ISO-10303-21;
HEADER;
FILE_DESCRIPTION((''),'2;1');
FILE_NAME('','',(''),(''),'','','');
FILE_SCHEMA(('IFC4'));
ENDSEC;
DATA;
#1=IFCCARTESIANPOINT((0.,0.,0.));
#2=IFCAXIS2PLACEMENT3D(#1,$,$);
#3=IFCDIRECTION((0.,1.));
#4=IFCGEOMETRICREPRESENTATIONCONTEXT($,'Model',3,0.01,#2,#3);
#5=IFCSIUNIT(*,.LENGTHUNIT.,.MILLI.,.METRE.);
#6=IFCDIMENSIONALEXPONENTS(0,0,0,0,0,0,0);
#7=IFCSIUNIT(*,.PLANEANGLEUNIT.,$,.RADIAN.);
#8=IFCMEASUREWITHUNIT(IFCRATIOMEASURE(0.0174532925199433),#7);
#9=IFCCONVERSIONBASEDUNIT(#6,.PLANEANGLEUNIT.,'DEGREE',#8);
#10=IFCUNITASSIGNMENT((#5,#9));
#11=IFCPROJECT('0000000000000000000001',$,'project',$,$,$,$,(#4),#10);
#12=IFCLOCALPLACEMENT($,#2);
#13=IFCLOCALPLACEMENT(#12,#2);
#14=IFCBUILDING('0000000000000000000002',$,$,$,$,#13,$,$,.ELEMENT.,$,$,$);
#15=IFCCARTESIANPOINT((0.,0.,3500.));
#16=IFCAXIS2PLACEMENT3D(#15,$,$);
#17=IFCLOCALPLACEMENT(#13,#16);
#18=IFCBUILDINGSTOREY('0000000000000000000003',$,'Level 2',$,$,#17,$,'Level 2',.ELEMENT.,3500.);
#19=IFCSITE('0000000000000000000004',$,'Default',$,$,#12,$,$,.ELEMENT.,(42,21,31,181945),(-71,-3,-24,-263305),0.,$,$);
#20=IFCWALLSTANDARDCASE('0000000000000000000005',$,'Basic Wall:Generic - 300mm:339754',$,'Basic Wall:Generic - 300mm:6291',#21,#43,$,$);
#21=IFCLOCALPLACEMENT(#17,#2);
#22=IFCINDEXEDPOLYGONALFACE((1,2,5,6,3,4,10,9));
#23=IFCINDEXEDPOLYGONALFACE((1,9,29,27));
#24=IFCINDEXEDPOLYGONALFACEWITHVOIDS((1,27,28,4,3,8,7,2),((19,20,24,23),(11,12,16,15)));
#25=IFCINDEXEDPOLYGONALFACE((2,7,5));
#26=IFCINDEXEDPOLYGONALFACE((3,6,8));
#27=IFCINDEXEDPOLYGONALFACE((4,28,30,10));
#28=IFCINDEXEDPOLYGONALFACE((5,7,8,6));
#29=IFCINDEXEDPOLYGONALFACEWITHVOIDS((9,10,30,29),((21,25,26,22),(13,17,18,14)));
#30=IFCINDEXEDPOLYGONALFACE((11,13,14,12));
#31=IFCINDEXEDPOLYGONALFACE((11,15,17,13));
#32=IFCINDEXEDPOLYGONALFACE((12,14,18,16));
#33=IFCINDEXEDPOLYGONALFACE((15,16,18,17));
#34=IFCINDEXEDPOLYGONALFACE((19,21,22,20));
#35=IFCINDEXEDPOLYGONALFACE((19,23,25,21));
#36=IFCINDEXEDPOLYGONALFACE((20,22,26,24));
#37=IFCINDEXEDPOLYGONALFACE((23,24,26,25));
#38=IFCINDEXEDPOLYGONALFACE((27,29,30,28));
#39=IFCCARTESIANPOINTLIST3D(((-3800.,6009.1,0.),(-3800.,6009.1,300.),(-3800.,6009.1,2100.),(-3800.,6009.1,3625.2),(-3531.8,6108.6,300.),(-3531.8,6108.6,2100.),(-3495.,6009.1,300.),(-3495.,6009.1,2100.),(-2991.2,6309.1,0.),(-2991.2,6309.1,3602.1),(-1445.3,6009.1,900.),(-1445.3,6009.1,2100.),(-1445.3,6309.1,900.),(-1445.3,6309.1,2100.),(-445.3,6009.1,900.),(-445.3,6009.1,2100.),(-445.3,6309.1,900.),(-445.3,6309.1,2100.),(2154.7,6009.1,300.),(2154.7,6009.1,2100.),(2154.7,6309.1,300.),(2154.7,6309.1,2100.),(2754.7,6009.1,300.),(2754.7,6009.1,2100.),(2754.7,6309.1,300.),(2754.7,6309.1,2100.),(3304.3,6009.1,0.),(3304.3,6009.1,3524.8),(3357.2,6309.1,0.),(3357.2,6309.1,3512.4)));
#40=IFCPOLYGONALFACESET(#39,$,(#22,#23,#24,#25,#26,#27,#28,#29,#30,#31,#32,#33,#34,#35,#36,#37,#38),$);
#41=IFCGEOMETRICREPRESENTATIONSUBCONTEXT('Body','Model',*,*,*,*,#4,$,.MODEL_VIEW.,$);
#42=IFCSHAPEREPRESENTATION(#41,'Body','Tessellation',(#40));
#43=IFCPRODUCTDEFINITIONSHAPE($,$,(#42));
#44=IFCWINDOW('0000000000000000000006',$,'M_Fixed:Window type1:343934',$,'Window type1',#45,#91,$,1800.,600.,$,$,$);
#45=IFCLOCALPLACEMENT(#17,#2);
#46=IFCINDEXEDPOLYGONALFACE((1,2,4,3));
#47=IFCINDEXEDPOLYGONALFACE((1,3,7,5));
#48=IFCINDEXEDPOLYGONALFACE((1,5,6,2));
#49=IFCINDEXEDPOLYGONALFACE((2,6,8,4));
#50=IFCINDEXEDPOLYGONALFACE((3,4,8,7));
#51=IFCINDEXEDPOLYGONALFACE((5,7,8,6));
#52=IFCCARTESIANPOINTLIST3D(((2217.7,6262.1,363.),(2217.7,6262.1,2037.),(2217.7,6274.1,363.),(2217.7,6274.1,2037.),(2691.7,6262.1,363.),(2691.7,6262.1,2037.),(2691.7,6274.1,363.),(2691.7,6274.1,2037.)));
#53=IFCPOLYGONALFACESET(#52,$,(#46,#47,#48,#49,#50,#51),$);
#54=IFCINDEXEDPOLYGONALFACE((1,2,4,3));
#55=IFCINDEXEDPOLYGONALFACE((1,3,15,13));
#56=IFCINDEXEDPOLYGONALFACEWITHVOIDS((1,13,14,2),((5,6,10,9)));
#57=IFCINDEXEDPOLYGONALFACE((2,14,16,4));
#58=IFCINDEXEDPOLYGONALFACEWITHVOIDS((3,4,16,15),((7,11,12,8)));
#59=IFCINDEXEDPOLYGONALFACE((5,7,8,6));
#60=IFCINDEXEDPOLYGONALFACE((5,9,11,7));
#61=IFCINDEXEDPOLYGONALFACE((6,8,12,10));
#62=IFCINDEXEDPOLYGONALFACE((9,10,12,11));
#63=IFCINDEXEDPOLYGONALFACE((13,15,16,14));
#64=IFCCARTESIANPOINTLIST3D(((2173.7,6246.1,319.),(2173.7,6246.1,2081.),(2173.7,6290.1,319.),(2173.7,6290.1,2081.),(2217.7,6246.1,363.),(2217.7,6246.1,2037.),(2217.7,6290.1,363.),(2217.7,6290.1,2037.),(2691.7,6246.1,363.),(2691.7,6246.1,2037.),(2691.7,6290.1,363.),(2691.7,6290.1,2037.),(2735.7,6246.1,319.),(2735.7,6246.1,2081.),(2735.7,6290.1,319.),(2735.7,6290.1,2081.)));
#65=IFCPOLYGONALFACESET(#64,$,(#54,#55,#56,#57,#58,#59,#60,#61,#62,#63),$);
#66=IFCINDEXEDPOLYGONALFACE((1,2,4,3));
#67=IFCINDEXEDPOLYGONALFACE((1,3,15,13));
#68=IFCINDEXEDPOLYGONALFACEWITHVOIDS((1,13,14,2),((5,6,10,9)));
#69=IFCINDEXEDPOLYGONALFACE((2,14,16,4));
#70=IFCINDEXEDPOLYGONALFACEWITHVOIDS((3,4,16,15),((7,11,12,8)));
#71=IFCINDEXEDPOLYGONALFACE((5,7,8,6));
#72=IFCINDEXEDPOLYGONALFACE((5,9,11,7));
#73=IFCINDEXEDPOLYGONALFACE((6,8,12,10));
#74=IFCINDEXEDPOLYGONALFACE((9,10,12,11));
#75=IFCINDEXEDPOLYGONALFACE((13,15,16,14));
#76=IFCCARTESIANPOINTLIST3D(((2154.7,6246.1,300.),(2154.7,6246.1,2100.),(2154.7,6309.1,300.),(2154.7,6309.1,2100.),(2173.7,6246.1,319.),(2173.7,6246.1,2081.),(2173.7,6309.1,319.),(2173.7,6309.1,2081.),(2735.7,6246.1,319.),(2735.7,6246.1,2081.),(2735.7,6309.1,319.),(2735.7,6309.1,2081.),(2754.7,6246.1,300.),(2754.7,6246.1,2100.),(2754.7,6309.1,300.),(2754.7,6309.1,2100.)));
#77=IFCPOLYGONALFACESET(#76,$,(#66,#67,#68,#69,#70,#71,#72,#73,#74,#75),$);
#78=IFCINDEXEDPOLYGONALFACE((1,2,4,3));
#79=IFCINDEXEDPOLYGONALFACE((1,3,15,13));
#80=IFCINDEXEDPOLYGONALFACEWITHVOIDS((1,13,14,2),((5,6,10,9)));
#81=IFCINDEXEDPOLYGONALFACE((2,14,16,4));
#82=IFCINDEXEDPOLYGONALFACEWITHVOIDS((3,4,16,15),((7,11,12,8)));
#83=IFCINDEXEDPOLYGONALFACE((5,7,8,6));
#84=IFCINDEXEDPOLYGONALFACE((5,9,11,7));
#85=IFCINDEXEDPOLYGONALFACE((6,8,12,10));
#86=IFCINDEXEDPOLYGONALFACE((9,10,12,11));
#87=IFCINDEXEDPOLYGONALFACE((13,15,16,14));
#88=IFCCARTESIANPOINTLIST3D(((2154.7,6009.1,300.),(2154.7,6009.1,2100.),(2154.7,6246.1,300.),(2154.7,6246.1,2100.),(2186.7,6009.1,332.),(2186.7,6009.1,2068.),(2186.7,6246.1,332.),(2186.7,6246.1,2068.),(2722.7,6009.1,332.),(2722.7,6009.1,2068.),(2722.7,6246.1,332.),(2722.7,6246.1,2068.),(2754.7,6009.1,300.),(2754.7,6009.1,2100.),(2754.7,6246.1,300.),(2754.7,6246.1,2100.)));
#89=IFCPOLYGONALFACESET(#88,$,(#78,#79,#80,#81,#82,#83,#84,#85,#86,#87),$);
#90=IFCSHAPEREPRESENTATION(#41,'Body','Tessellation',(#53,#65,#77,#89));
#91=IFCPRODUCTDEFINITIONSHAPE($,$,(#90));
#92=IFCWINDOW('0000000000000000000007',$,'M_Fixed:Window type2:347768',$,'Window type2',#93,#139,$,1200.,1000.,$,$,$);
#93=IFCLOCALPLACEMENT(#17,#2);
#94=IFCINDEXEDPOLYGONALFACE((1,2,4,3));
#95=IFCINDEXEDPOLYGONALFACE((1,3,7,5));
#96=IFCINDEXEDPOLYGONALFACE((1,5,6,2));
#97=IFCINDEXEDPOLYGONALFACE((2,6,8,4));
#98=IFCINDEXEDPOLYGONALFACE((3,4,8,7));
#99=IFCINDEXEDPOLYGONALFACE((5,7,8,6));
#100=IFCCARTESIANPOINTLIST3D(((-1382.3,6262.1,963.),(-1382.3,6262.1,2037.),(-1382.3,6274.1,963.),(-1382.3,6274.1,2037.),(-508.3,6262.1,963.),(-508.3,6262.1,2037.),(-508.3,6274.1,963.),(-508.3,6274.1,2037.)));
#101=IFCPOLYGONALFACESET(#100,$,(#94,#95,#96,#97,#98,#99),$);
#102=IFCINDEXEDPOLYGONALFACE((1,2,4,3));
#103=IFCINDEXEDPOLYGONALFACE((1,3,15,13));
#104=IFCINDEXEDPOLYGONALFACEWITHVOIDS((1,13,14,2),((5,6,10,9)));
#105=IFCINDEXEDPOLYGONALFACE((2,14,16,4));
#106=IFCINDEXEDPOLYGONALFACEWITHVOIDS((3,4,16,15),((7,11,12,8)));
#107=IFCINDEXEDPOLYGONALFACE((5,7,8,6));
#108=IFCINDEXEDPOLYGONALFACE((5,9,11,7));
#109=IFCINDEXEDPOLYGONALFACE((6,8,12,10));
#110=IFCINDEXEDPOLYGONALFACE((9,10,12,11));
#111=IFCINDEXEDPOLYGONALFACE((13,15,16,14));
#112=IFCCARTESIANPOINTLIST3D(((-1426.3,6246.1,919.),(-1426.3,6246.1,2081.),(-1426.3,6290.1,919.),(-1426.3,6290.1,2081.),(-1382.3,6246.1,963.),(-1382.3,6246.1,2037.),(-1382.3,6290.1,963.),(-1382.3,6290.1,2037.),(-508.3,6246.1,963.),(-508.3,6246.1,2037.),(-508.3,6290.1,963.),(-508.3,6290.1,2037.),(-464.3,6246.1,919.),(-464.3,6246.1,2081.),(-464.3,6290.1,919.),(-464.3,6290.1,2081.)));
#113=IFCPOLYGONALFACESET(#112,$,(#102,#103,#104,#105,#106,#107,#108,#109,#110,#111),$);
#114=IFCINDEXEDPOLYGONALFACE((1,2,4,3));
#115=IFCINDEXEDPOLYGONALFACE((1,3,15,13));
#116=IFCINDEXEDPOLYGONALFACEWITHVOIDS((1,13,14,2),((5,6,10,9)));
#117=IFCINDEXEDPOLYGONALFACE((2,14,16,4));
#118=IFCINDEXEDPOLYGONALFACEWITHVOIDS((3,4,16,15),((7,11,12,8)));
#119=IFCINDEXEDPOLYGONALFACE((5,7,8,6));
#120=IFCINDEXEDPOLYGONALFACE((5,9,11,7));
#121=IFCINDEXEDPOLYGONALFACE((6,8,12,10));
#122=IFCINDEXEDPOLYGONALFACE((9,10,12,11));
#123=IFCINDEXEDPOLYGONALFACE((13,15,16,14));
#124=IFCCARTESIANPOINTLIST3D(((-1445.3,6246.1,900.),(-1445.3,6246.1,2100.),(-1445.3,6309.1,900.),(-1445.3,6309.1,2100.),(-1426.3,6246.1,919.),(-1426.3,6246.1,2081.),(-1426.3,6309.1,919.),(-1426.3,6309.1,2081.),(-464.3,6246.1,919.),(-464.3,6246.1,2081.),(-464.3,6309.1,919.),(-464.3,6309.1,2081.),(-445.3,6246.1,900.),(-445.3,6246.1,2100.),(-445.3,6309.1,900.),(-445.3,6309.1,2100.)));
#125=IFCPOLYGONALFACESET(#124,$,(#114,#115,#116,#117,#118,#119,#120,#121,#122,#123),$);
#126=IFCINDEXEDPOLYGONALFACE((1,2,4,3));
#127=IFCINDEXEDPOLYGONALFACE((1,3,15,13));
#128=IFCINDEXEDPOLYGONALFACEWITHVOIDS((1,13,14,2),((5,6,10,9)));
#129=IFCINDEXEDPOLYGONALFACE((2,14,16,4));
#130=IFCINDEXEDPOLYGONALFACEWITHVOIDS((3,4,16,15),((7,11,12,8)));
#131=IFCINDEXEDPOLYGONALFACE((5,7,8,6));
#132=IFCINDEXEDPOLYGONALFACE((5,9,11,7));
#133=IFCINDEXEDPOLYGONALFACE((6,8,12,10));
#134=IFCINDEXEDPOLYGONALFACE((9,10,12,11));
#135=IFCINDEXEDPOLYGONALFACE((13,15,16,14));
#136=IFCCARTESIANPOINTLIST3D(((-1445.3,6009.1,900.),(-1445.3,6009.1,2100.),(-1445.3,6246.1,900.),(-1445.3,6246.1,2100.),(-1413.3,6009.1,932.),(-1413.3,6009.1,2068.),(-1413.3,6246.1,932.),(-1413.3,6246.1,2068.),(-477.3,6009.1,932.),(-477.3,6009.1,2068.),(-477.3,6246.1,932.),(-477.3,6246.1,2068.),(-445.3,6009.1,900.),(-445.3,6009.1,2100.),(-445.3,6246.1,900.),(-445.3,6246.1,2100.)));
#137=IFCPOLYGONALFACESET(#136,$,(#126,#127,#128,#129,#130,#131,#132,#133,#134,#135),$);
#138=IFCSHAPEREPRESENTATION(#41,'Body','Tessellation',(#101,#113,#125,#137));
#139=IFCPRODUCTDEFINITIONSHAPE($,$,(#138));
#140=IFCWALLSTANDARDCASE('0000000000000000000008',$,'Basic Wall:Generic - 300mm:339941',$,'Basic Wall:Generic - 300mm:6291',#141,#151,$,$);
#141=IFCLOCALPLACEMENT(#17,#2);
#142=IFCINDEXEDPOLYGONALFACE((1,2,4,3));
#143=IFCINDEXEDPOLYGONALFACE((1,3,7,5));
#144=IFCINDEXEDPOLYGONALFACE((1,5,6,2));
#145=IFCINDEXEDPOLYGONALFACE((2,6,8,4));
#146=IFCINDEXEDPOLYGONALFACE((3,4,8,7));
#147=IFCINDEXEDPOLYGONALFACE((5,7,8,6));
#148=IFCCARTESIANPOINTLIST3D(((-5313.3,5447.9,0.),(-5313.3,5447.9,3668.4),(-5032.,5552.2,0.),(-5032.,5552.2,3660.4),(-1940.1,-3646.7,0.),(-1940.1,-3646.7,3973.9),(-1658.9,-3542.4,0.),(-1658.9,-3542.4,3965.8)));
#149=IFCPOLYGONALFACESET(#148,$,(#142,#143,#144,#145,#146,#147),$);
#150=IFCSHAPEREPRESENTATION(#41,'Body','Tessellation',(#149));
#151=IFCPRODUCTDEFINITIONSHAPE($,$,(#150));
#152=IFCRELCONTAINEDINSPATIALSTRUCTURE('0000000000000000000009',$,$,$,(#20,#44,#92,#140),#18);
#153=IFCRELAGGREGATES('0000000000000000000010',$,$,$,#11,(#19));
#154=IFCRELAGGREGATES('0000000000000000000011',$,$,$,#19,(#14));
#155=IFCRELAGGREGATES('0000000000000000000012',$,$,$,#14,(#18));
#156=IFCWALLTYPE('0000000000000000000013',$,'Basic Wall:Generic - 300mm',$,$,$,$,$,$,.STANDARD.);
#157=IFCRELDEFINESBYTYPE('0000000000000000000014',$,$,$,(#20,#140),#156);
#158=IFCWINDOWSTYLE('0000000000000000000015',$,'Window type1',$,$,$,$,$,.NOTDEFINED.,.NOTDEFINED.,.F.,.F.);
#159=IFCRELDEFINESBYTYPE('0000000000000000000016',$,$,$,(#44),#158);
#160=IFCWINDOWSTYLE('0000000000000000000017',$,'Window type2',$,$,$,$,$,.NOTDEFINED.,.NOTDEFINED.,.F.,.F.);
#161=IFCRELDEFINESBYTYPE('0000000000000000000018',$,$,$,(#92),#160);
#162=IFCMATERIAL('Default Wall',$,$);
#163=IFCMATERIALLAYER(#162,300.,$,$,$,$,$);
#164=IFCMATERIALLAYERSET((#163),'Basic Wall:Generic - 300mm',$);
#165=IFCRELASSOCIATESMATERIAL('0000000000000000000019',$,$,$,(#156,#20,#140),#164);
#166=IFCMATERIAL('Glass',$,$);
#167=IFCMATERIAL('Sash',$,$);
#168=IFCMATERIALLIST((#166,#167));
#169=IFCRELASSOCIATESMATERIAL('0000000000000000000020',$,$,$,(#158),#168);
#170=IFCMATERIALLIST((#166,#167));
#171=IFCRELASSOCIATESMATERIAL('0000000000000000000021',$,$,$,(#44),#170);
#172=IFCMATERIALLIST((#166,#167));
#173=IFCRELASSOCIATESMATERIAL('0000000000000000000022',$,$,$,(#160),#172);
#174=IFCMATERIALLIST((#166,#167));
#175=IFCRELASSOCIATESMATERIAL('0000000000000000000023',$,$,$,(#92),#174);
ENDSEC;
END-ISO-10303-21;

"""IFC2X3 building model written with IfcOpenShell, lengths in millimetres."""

from ifc_helpers import new_model, entity, si_unit, converted_unit, direction, frame, frame_2d, origin, place, context, subcontext, project, spatial, polyline, rectangle, outline, extrude, clip, bounded_halfspace, source, transform, mapped, material, material_list, layer, layer_set, layer_usage, type_object, type_shapes, element, fill, save


model = new_model("IFC2X3")

# Units and contexts
model_context = context("Model", 3, precision=0.01, world=origin(), true_north=direction((0.0, 1.0)))
body_context = subcontext(model_context, "Body", "Model", "MODEL_VIEW")
ifc_project = project(units=[si_unit("LENGTHUNIT", "METRE", prefix="MILLI"), converted_unit("PLANEANGLEUNIT", "DEGREE", entity("IfcRatioMeasure", 0.0174532925199433), si_unit("PLANEANGLEUNIT", "RADIAN"), dimensions=[0, 0, 0, 0, 0, 0, 0])], contexts=[model_context])

# Site, building, storey
site_placement = place(None, origin())
site = spatial("IfcSite", under=ifc_project, at=site_placement, Name="Default", CompositionType="ELEMENT", RefLatitude=(42, 21, 31, 181945), RefLongitude=(-71, -3, -24, -263305), RefElevation=0.0)
building_placement = place(site_placement, origin())
building = spatial("IfcBuilding", under=site, at=building_placement, CompositionType="ELEMENT")
storey_placement = place(building_placement, frame((0.0, 0.0, 3500.0)))
storey = spatial("IfcBuildingStorey", under=building, at=storey_placement, Name="Level 2", LongName="Level 2", CompositionType="ELEMENT", Elevation=3500.0)

# Wall, openings, windows
ifc_material_1 = material(Name="Default Wall")
ifc_layer_1 = layer(ifc_material_1, 300.0)
ifc_layer_set_1 = layer_set([ifc_layer_1], Name="Basic Wall:Generic - 300mm")
ifc_layer_usage_1 = layer_usage(ifc_layer_set_1, "AXIS2", "NEGATIVE", 150.0)
wall_type = type_object("IfcWallType", Name="Basic Wall:Generic - 300mm", PredefinedType="STANDARD", material=ifc_layer_set_1)
wall_1_placement = place(storey_placement, frame((-3800.0, 6159.1, 0.0)))
wall_1 = element("IfcWallStandardCase", 1, at=wall_1_placement, inside=storey, type_object=wall_type, material=ifc_layer_usage_1, Name="Basic Wall:Generic - 300mm:339754", ObjectType="Basic Wall:Generic - 300mm:6291", context=body_context, shape_type="Clipping", body=[
    clip(extrude(outline(polyline([(7104.3, -150.0), (7157.2, 150.0), (808.9, 150.0), (0.0, -150.0), (862.7, -150.0), (7104.3, -150.0)])), origin(), (0.0, 0.0, 1.0), 3625.2), bounded_halfspace(frame((0.0, -150.0, 3625.2), z_axis=(0.014121, 0.038797, 0.999147), x_axis=(-0.939693, 0.34202, 0.0)), False, frame((0.0, -150.0, 3625.2)), polyline([(0.0, 0.0), (862.7, 0.0), (7104.3, 0.0), (7157.2, 300.0), (808.9, 300.0), (0.0, 0.0)]))),
])
opening_1_placement = place(wall_1_placement, origin())
element("IfcOpeningElement", 2, at=opening_1_placement, cuts=wall_1, ObjectType="Opening", context=body_context, shape_type="SweptSolid", body=[
    extrude(rectangle(XDim=1800.0, YDim=600.0, at=frame_2d((0.0, 0.0), x_axis=(0.0, 1.0))), frame((91.2, -436.1, 1200.0), z_axis=(-0.347744, 0.937589, 0.0), x_axis=(-0.937589, -0.347744, 0.0)), (0.0, 0.0, 1.0), 300.0),
])
opening_2_placement = place(wall_1_placement, frame((5954.7, -150.0, 300.0)))
opening_2 = element("IfcOpeningElement", 3, at=opening_2_placement, cuts=wall_1, ObjectType="Opening", context=body_context, shape_type="SweptSolid", body=[
    extrude(rectangle(XDim=1800.0, YDim=600.0, at=frame_2d((900.0, 300.0), x_axis=(1.0, 0.0))), frame((0.0, 0.0, 0.0), z_axis=(0.0, 1.0, 0.0), x_axis=(0.0, 0.0, 1.0)), (0.0, 0.0, 1.0), 300.0),
])
opening_3_placement = place(wall_1_placement, frame((2354.7, -150.0, 900.0)))
opening_3 = element("IfcOpeningElement", 4, at=opening_3_placement, cuts=wall_1, ObjectType="Opening", context=body_context, shape_type="SweptSolid", body=[
    extrude(rectangle(XDim=1200.0, YDim=1000.0, at=frame_2d((600.0, 500.0), x_axis=(1.0, 0.0))), frame((0.0, 0.0, 0.0), z_axis=(0.0, 1.0, 0.0), x_axis=(0.0, 0.0, 1.0)), (0.0, 0.0, 1.0), 300.0),
])
ifc_material_2 = material(Name="Glass")
ifc_material_3 = material(Name="Sash")
ifc_material_list_1 = material_list([ifc_material_2, ifc_material_3])
ifc_material_list_2 = material_list([ifc_material_2, ifc_material_3])
window_style_1 = type_object("IfcWindowStyle", Name="Window type1", ConstructionType="NOTDEFINED", OperationType="NOTDEFINED", ParameterTakesPrecedence=False, Sizeable=False, material=ifc_material_list_2)
shared_shape_1 = source(origin(), body_context, "Body", "SweptSolid", [
    extrude(rectangle(XDim=12.0, YDim=474.0, at=frame_2d((0.0, 0.0), x_axis=(1.0, 0.0))), frame((300.0, 259.0, 63.0), z_axis=(0.0, 0.0, 1.0), x_axis=(0.0, -1.0, 0.0)), (0.0, 0.0, 1.0), 1674.0),
    extrude(outline(polyline([(-281.0, -881.0), (281.0, -881.0), (281.0, 881.0), (-281.0, 881.0), (-281.0, -881.0)]), holes=[polyline([(-237.0, -837.0), (-237.0, 837.0), (237.0, 837.0), (237.0, -837.0), (-237.0, -837.0)])]), frame((300.0, 237.0, 900.0), z_axis=(0.0, 1.0, 0.0), x_axis=(1.0, 0.0, 0.0)), (0.0, 0.0, 1.0), 44.0),
    extrude(outline(polyline([(-300.0, -900.0), (300.0, -900.0), (300.0, 900.0), (-300.0, 900.0), (-300.0, -900.0)]), holes=[polyline([(-281.0, -881.0), (-281.0, 881.0), (281.0, 881.0), (281.0, -881.0), (-281.0, -881.0)])]), frame((300.0, 237.0, 900.0), z_axis=(0.0, 1.0, 0.0), x_axis=(1.0, 0.0, 0.0)), (0.0, 0.0, 1.0), 63.0),
    extrude(outline(polyline([(-300.0, -900.0), (300.0, -900.0), (300.0, 900.0), (-300.0, 900.0), (-300.0, -900.0)]), holes=[polyline([(-268.0, -868.0), (-268.0, 868.0), (268.0, 868.0), (268.0, -868.0), (-268.0, -868.0)])]), frame((300.0, 0.0, 900.0), z_axis=(0.0, 1.0, 0.0), x_axis=(1.0, 0.0, 0.0)), (0.0, 0.0, 1.0), 237.0),
])
type_shapes(window_style_1, [shared_shape_1])
window_1_placement = place(opening_2_placement, origin())
window_1 = element("IfcWindow", 5, at=window_1_placement, inside=storey, type_object=window_style_1, material=ifc_material_list_1, Name="M_Fixed:Window type1:343934", ObjectType="Window type1", OverallHeight=1800.0, OverallWidth=600.0, context=body_context, shape_type="MappedRepresentation", body=[
    mapped(shared_shape_1, transform((0.0, 0.0, 0.0), scale=1.0)),
])
fill(opening_2, window_1)
ifc_material_list_3 = material_list([ifc_material_2, ifc_material_3])
ifc_material_list_4 = material_list([ifc_material_2, ifc_material_3])
window_style_2 = type_object("IfcWindowStyle", Name="Window type2", ConstructionType="NOTDEFINED", OperationType="NOTDEFINED", ParameterTakesPrecedence=False, Sizeable=False, material=ifc_material_list_4)
shared_shape_2 = source(origin(), body_context, "Body", "SweptSolid", [
    extrude(rectangle(XDim=12.0, YDim=874.0, at=frame_2d((0.0, 0.0), x_axis=(1.0, 0.0))), frame((500.0, 259.0, 63.0), z_axis=(0.0, 0.0, 1.0), x_axis=(0.0, -1.0, 0.0)), (0.0, 0.0, 1.0), 1074.0),
    extrude(outline(polyline([(-481.0, -581.0), (481.0, -581.0), (481.0, 581.0), (-481.0, 581.0), (-481.0, -581.0)]), holes=[polyline([(-437.0, -537.0), (-437.0, 537.0), (437.0, 537.0), (437.0, -537.0), (-437.0, -537.0)])]), frame((500.0, 237.0, 600.0), z_axis=(0.0, 1.0, 0.0), x_axis=(1.0, 0.0, 0.0)), (0.0, 0.0, 1.0), 44.0),
    extrude(outline(polyline([(-500.0, -600.0), (500.0, -600.0), (500.0, 600.0), (-500.0, 600.0), (-500.0, -600.0)]), holes=[polyline([(-481.0, -581.0), (-481.0, 581.0), (481.0, 581.0), (481.0, -581.0), (-481.0, -581.0)])]), frame((500.0, 237.0, 600.0), z_axis=(0.0, 1.0, 0.0), x_axis=(1.0, 0.0, 0.0)), (0.0, 0.0, 1.0), 63.0),
    extrude(outline(polyline([(-500.0, -600.0), (500.0, -600.0), (500.0, 600.0), (-500.0, 600.0), (-500.0, -600.0)]), holes=[polyline([(-468.0, -568.0), (-468.0, 568.0), (468.0, 568.0), (468.0, -568.0), (-468.0, -568.0)])]), frame((500.0, 0.0, 600.0), z_axis=(0.0, 1.0, 0.0), x_axis=(1.0, 0.0, 0.0)), (0.0, 0.0, 1.0), 237.0),
])
type_shapes(window_style_2, [shared_shape_2])
window_2_placement = place(opening_3_placement, origin())
window_2 = element("IfcWindow", 6, at=window_2_placement, inside=storey, type_object=window_style_2, material=ifc_material_list_3, Name="M_Fixed:Window type2:347768", ObjectType="Window type2", OverallHeight=1200.0, OverallWidth=1000.0, context=body_context, shape_type="MappedRepresentation", body=[
    mapped(shared_shape_2, transform((0.0, 0.0, 0.0), scale=1.0)),
])
fill(opening_3, window_2)

# Wall
ifc_layer_usage_2 = layer_usage(ifc_layer_set_1, "AXIS2", "NEGATIVE", 150.0)
wall_2_placement = place(storey_placement, frame((-1799.5, -3594.6, 0.0), z_axis=(0.0, 0.0, 1.0), x_axis=(-0.347744, 0.937589, 0.0)))
element("IfcWallStandardCase", 7, at=wall_2_placement, inside=storey, type_object=wall_type, material=ifc_layer_usage_2, Name="Basic Wall:Generic - 300mm:339941", ObjectType="Basic Wall:Generic - 300mm:6291", context=body_context, shape_type="Clipping", body=[
    clip(extrude(rectangle(XDim=9700.0, YDim=300.0, at=frame_2d((4850.0, 0.0), x_axis=(-1.0, 0.0))), origin(), (0.0, 0.0, 1.0), 3973.9), bounded_halfspace(frame((0.0, -150.0, 3965.8), z_axis=(0.031465, -0.026731, 0.999147), x_axis=(0.647447, 0.76211, 0.0)), False, frame((0.0, -150.0, 3965.8)), polyline([(0.0, 0.0), (9400.0, 0.0), (9700.0, 0.0), (9700.0, 300.0), (0.0, 300.0), (0.0, 0.0)]))),
])

save(model, "model.ifc")
